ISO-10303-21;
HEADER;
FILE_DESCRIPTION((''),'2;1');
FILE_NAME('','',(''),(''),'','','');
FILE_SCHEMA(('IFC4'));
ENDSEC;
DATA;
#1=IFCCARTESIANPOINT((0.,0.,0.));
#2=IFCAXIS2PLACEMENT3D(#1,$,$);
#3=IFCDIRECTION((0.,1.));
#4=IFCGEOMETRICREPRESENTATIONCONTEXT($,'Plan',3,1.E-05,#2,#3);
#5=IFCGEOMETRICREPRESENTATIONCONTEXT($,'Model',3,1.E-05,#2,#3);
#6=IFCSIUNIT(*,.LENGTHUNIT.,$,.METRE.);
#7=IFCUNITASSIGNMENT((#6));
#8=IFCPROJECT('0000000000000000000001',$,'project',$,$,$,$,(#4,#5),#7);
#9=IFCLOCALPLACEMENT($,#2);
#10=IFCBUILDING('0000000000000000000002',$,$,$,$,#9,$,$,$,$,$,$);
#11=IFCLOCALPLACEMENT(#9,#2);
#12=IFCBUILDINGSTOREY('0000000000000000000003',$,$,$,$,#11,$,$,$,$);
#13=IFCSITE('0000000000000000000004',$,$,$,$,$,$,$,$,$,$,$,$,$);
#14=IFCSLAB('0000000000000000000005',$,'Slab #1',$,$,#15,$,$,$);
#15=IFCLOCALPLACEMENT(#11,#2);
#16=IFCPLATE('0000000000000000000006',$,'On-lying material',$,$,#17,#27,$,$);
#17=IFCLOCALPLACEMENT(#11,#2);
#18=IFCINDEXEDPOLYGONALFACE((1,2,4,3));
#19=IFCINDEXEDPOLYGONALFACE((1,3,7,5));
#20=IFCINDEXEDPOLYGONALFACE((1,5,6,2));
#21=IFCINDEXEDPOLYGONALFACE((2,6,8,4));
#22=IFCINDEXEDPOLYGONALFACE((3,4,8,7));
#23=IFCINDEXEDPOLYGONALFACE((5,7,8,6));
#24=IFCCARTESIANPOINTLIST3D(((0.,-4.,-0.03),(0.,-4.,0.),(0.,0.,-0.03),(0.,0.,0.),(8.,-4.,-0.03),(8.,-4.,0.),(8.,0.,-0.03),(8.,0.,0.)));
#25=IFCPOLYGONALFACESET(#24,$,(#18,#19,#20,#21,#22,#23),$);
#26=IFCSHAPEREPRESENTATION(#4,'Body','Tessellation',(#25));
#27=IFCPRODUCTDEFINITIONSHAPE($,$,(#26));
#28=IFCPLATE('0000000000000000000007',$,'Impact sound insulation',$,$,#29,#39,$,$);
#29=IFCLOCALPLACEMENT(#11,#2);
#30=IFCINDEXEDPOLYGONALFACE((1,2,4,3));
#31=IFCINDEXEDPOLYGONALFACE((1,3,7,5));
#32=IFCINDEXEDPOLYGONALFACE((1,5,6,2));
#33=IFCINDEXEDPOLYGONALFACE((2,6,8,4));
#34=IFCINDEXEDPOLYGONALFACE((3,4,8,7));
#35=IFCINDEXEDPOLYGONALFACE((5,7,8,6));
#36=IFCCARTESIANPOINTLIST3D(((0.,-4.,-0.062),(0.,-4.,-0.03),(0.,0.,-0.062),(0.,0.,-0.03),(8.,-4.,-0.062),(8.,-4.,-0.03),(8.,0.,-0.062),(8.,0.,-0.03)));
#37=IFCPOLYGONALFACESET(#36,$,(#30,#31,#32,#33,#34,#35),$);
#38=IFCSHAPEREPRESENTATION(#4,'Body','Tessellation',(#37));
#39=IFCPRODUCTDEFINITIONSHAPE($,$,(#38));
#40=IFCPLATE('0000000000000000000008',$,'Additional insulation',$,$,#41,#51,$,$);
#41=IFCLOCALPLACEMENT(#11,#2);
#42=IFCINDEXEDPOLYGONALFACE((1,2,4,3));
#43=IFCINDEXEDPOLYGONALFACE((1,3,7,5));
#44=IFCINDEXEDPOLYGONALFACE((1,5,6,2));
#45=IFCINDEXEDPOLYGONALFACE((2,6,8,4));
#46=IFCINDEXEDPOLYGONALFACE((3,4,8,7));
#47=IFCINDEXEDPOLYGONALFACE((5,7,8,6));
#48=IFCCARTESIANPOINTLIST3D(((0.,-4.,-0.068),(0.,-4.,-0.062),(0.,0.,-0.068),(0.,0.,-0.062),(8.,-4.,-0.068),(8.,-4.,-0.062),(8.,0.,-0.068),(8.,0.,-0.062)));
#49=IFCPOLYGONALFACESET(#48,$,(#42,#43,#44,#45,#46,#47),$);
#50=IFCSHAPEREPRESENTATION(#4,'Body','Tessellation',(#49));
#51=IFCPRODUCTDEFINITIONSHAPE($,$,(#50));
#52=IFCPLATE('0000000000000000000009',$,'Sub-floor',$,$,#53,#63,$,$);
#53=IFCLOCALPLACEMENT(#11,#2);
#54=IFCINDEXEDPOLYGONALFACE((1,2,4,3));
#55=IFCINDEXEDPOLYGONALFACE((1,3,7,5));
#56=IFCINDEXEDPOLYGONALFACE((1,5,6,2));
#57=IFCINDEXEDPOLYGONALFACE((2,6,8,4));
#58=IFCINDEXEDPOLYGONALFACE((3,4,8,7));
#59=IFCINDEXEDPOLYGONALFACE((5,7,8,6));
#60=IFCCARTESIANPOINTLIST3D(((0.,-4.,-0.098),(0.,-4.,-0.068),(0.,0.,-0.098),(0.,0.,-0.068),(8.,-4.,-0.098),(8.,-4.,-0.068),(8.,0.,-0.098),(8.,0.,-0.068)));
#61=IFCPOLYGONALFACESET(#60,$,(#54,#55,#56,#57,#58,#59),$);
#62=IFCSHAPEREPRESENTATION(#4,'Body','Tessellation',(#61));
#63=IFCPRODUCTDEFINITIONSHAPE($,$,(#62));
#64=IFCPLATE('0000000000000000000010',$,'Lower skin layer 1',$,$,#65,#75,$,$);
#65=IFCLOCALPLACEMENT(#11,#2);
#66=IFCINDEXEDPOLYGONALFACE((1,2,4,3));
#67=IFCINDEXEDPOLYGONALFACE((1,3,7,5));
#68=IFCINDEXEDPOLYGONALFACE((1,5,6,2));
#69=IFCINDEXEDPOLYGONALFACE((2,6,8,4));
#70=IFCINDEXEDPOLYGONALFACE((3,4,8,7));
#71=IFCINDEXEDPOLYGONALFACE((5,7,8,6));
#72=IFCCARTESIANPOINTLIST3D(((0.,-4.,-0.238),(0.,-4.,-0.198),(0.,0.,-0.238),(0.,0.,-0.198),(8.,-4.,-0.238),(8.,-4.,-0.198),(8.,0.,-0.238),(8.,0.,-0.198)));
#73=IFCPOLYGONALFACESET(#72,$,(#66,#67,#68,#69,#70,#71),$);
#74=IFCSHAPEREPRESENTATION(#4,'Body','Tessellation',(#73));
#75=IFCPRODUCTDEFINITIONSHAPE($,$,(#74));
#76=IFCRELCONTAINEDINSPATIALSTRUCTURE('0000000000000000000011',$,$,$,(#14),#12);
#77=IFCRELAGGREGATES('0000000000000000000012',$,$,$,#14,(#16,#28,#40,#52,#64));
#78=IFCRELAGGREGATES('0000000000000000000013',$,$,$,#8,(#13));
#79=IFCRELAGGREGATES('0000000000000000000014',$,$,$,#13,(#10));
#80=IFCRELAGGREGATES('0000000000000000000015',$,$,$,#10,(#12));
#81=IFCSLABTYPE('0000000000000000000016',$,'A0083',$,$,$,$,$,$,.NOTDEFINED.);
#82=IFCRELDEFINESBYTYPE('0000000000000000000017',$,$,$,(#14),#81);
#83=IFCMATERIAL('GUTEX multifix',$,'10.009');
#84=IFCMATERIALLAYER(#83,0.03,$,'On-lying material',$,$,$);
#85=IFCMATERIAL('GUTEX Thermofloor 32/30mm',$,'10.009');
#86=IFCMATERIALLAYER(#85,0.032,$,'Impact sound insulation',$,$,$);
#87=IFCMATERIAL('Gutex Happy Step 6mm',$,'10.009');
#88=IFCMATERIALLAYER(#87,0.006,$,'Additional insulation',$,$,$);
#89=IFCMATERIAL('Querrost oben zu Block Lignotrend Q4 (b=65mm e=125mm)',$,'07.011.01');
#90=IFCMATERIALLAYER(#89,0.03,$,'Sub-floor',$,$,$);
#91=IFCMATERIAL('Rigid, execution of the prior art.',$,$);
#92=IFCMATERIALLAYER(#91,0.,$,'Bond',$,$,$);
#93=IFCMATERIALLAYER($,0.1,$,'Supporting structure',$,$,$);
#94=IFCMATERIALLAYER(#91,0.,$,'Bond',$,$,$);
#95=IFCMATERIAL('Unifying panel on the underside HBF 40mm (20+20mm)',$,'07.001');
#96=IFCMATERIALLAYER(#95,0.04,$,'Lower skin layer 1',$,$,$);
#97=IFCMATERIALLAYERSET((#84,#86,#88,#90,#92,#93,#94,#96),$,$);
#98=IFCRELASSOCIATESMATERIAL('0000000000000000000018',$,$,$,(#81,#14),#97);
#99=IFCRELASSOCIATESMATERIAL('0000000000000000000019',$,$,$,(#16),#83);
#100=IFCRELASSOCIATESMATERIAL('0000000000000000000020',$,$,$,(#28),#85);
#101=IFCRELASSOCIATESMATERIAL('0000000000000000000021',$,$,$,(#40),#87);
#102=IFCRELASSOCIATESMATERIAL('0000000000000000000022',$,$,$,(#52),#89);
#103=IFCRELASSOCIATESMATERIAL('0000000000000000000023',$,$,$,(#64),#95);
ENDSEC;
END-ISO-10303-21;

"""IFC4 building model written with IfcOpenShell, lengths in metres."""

from ifc_helpers import new_model, si_unit, direction, frame, frame_2d, origin, origin_with_axes, place, context, project, spatial, rectangle, extrude, material, layer, layer_set, type_object, element, aggregate, save


model = new_model("IFC4")

# Units and contexts
plan_context = context("Plan", 3, precision=1e-05, world=origin(), true_north=direction((0.0, 1.0)))
model_context = context("Model", 3, precision=1e-05, world=origin(), true_north=direction((0.0, 1.0)))
ifc_project = project(units=[si_unit("LENGTHUNIT", "METRE")], contexts=[plan_context, model_context])

# Site, building, storey
site = spatial("IfcSite", under=ifc_project)
building_placement = place(None, origin())
building = spatial("IfcBuilding", under=site, at=building_placement)
storey_placement = place(building_placement, origin())
storey = spatial("IfcBuildingStorey", under=building, at=storey_placement)

# Slab, plates
ifc_material_1 = material(Name="GUTEX multifix", Category="10.009")
ifc_layer_1 = layer(ifc_material_1, 0.03, Name="On-lying material")
ifc_material_2 = material(Name="GUTEX Thermofloor 32/30mm", Category="10.009")
ifc_layer_2 = layer(ifc_material_2, 0.032, Name="Impact sound insulation")
ifc_material_3 = material(Name="Gutex Happy Step 6mm", Category="10.009")
ifc_layer_3 = layer(ifc_material_3, 0.006, Name="Additional insulation")
ifc_material_4 = material(Name="Querrost oben zu Block Lignotrend Q4 (b=65mm e=125mm)", Category="07.011.01")
ifc_layer_4 = layer(ifc_material_4, 0.03, Name="Sub-floor")
ifc_material_5 = material(Name="Rigid, execution of the prior art.")
ifc_layer_5 = layer(ifc_material_5, 0.0, Name="Bond")
ifc_layer_6 = layer(None, 0.1, Name="Supporting structure")
ifc_layer_7 = layer(ifc_material_5, 0.0, Name="Bond")
ifc_material_6 = material(Name="Unifying panel on the underside HBF 40mm (20+20mm)", Category="07.001")
ifc_layer_8 = layer(ifc_material_6, 0.04, Name="Lower skin layer 1")
ifc_layer_set = layer_set([ifc_layer_1, ifc_layer_2, ifc_layer_3, ifc_layer_4, ifc_layer_5, ifc_layer_6, ifc_layer_7, ifc_layer_8])
slab_type = type_object("IfcSlabType", Name="A0083", PredefinedType="NOTDEFINED", material=ifc_layer_set)
slab_placement = place(None, frame((0.0, 0.0, 0.0), z_axis=(0.0, 0.0, -1.0), x_axis=(1.0, 0.0, 0.0)))
slab = element("IfcSlab", 1, at=slab_placement, inside=storey, type_object=slab_type, material=ifc_layer_set, Name="Slab #1")
plate_1_placement = place(slab_placement, origin())
plate_1 = element("IfcPlate", 2, at=plate_1_placement, material=ifc_material_1, Name="On-lying material", context=plan_context, shape_type="SweptSolid", body=[
    extrude(rectangle(XDim=8.0, YDim=4.0, at=frame_2d((4.0, 2.0), x_axis=(1.0, 0.0))), origin_with_axes(), (0.0, 0.0, 1.0), 0.03),
])
plate_2_placement = place(slab_placement, origin())
plate_2 = element("IfcPlate", 3, at=plate_2_placement, material=ifc_material_2, Name="Impact sound insulation", context=plan_context, shape_type="SweptSolid", body=[
    extrude(rectangle(XDim=8.0, YDim=4.0, at=frame_2d((4.0, 2.0), x_axis=(1.0, 0.0))), frame((0.0, 0.0, 0.03), z_axis=(0.0, 0.0, 1.0), x_axis=(1.0, 0.0, 0.0)), (0.0, 0.0, 1.0), 0.032),
])
plate_3_placement = place(slab_placement, origin())
plate_3 = element("IfcPlate", 4, at=plate_3_placement, material=ifc_material_3, Name="Additional insulation", context=plan_context, shape_type="SweptSolid", body=[
    extrude(rectangle(XDim=8.0, YDim=4.0, at=frame_2d((4.0, 2.0), x_axis=(1.0, 0.0))), frame((0.0, 0.0, 0.062), z_axis=(0.0, 0.0, 1.0), x_axis=(1.0, 0.0, 0.0)), (0.0, 0.0, 1.0), 0.006),
])
plate_4_placement = place(slab_placement, origin())
plate_4 = element("IfcPlate", 5, at=plate_4_placement, material=ifc_material_4, Name="Sub-floor", context=plan_context, shape_type="SweptSolid", body=[
    extrude(rectangle(XDim=8.0, YDim=4.0, at=frame_2d((4.0, 2.0), x_axis=(1.0, 0.0))), frame((0.0, 0.0, 0.068), z_axis=(0.0, 0.0, 1.0), x_axis=(1.0, 0.0, 0.0)), (0.0, 0.0, 1.0), 0.03),
])
plate_5_placement = place(slab_placement, origin())
plate_5 = element("IfcPlate", 6, at=plate_5_placement, material=ifc_material_6, Name="Lower skin layer 1", context=plan_context, shape_type="SweptSolid", body=[
    extrude(rectangle(XDim=8.0, YDim=4.0, at=frame_2d((4.0, 2.0), x_axis=(1.0, 0.0))), frame((0.0, 0.0, 0.198), z_axis=(0.0, 0.0, 1.0), x_axis=(1.0, 0.0, 0.0)), (0.0, 0.0, 1.0), 0.04),
])
aggregate(slab, [plate_1, plate_2, plate_3, plate_4, plate_5])

save(model, "model.ifc")
